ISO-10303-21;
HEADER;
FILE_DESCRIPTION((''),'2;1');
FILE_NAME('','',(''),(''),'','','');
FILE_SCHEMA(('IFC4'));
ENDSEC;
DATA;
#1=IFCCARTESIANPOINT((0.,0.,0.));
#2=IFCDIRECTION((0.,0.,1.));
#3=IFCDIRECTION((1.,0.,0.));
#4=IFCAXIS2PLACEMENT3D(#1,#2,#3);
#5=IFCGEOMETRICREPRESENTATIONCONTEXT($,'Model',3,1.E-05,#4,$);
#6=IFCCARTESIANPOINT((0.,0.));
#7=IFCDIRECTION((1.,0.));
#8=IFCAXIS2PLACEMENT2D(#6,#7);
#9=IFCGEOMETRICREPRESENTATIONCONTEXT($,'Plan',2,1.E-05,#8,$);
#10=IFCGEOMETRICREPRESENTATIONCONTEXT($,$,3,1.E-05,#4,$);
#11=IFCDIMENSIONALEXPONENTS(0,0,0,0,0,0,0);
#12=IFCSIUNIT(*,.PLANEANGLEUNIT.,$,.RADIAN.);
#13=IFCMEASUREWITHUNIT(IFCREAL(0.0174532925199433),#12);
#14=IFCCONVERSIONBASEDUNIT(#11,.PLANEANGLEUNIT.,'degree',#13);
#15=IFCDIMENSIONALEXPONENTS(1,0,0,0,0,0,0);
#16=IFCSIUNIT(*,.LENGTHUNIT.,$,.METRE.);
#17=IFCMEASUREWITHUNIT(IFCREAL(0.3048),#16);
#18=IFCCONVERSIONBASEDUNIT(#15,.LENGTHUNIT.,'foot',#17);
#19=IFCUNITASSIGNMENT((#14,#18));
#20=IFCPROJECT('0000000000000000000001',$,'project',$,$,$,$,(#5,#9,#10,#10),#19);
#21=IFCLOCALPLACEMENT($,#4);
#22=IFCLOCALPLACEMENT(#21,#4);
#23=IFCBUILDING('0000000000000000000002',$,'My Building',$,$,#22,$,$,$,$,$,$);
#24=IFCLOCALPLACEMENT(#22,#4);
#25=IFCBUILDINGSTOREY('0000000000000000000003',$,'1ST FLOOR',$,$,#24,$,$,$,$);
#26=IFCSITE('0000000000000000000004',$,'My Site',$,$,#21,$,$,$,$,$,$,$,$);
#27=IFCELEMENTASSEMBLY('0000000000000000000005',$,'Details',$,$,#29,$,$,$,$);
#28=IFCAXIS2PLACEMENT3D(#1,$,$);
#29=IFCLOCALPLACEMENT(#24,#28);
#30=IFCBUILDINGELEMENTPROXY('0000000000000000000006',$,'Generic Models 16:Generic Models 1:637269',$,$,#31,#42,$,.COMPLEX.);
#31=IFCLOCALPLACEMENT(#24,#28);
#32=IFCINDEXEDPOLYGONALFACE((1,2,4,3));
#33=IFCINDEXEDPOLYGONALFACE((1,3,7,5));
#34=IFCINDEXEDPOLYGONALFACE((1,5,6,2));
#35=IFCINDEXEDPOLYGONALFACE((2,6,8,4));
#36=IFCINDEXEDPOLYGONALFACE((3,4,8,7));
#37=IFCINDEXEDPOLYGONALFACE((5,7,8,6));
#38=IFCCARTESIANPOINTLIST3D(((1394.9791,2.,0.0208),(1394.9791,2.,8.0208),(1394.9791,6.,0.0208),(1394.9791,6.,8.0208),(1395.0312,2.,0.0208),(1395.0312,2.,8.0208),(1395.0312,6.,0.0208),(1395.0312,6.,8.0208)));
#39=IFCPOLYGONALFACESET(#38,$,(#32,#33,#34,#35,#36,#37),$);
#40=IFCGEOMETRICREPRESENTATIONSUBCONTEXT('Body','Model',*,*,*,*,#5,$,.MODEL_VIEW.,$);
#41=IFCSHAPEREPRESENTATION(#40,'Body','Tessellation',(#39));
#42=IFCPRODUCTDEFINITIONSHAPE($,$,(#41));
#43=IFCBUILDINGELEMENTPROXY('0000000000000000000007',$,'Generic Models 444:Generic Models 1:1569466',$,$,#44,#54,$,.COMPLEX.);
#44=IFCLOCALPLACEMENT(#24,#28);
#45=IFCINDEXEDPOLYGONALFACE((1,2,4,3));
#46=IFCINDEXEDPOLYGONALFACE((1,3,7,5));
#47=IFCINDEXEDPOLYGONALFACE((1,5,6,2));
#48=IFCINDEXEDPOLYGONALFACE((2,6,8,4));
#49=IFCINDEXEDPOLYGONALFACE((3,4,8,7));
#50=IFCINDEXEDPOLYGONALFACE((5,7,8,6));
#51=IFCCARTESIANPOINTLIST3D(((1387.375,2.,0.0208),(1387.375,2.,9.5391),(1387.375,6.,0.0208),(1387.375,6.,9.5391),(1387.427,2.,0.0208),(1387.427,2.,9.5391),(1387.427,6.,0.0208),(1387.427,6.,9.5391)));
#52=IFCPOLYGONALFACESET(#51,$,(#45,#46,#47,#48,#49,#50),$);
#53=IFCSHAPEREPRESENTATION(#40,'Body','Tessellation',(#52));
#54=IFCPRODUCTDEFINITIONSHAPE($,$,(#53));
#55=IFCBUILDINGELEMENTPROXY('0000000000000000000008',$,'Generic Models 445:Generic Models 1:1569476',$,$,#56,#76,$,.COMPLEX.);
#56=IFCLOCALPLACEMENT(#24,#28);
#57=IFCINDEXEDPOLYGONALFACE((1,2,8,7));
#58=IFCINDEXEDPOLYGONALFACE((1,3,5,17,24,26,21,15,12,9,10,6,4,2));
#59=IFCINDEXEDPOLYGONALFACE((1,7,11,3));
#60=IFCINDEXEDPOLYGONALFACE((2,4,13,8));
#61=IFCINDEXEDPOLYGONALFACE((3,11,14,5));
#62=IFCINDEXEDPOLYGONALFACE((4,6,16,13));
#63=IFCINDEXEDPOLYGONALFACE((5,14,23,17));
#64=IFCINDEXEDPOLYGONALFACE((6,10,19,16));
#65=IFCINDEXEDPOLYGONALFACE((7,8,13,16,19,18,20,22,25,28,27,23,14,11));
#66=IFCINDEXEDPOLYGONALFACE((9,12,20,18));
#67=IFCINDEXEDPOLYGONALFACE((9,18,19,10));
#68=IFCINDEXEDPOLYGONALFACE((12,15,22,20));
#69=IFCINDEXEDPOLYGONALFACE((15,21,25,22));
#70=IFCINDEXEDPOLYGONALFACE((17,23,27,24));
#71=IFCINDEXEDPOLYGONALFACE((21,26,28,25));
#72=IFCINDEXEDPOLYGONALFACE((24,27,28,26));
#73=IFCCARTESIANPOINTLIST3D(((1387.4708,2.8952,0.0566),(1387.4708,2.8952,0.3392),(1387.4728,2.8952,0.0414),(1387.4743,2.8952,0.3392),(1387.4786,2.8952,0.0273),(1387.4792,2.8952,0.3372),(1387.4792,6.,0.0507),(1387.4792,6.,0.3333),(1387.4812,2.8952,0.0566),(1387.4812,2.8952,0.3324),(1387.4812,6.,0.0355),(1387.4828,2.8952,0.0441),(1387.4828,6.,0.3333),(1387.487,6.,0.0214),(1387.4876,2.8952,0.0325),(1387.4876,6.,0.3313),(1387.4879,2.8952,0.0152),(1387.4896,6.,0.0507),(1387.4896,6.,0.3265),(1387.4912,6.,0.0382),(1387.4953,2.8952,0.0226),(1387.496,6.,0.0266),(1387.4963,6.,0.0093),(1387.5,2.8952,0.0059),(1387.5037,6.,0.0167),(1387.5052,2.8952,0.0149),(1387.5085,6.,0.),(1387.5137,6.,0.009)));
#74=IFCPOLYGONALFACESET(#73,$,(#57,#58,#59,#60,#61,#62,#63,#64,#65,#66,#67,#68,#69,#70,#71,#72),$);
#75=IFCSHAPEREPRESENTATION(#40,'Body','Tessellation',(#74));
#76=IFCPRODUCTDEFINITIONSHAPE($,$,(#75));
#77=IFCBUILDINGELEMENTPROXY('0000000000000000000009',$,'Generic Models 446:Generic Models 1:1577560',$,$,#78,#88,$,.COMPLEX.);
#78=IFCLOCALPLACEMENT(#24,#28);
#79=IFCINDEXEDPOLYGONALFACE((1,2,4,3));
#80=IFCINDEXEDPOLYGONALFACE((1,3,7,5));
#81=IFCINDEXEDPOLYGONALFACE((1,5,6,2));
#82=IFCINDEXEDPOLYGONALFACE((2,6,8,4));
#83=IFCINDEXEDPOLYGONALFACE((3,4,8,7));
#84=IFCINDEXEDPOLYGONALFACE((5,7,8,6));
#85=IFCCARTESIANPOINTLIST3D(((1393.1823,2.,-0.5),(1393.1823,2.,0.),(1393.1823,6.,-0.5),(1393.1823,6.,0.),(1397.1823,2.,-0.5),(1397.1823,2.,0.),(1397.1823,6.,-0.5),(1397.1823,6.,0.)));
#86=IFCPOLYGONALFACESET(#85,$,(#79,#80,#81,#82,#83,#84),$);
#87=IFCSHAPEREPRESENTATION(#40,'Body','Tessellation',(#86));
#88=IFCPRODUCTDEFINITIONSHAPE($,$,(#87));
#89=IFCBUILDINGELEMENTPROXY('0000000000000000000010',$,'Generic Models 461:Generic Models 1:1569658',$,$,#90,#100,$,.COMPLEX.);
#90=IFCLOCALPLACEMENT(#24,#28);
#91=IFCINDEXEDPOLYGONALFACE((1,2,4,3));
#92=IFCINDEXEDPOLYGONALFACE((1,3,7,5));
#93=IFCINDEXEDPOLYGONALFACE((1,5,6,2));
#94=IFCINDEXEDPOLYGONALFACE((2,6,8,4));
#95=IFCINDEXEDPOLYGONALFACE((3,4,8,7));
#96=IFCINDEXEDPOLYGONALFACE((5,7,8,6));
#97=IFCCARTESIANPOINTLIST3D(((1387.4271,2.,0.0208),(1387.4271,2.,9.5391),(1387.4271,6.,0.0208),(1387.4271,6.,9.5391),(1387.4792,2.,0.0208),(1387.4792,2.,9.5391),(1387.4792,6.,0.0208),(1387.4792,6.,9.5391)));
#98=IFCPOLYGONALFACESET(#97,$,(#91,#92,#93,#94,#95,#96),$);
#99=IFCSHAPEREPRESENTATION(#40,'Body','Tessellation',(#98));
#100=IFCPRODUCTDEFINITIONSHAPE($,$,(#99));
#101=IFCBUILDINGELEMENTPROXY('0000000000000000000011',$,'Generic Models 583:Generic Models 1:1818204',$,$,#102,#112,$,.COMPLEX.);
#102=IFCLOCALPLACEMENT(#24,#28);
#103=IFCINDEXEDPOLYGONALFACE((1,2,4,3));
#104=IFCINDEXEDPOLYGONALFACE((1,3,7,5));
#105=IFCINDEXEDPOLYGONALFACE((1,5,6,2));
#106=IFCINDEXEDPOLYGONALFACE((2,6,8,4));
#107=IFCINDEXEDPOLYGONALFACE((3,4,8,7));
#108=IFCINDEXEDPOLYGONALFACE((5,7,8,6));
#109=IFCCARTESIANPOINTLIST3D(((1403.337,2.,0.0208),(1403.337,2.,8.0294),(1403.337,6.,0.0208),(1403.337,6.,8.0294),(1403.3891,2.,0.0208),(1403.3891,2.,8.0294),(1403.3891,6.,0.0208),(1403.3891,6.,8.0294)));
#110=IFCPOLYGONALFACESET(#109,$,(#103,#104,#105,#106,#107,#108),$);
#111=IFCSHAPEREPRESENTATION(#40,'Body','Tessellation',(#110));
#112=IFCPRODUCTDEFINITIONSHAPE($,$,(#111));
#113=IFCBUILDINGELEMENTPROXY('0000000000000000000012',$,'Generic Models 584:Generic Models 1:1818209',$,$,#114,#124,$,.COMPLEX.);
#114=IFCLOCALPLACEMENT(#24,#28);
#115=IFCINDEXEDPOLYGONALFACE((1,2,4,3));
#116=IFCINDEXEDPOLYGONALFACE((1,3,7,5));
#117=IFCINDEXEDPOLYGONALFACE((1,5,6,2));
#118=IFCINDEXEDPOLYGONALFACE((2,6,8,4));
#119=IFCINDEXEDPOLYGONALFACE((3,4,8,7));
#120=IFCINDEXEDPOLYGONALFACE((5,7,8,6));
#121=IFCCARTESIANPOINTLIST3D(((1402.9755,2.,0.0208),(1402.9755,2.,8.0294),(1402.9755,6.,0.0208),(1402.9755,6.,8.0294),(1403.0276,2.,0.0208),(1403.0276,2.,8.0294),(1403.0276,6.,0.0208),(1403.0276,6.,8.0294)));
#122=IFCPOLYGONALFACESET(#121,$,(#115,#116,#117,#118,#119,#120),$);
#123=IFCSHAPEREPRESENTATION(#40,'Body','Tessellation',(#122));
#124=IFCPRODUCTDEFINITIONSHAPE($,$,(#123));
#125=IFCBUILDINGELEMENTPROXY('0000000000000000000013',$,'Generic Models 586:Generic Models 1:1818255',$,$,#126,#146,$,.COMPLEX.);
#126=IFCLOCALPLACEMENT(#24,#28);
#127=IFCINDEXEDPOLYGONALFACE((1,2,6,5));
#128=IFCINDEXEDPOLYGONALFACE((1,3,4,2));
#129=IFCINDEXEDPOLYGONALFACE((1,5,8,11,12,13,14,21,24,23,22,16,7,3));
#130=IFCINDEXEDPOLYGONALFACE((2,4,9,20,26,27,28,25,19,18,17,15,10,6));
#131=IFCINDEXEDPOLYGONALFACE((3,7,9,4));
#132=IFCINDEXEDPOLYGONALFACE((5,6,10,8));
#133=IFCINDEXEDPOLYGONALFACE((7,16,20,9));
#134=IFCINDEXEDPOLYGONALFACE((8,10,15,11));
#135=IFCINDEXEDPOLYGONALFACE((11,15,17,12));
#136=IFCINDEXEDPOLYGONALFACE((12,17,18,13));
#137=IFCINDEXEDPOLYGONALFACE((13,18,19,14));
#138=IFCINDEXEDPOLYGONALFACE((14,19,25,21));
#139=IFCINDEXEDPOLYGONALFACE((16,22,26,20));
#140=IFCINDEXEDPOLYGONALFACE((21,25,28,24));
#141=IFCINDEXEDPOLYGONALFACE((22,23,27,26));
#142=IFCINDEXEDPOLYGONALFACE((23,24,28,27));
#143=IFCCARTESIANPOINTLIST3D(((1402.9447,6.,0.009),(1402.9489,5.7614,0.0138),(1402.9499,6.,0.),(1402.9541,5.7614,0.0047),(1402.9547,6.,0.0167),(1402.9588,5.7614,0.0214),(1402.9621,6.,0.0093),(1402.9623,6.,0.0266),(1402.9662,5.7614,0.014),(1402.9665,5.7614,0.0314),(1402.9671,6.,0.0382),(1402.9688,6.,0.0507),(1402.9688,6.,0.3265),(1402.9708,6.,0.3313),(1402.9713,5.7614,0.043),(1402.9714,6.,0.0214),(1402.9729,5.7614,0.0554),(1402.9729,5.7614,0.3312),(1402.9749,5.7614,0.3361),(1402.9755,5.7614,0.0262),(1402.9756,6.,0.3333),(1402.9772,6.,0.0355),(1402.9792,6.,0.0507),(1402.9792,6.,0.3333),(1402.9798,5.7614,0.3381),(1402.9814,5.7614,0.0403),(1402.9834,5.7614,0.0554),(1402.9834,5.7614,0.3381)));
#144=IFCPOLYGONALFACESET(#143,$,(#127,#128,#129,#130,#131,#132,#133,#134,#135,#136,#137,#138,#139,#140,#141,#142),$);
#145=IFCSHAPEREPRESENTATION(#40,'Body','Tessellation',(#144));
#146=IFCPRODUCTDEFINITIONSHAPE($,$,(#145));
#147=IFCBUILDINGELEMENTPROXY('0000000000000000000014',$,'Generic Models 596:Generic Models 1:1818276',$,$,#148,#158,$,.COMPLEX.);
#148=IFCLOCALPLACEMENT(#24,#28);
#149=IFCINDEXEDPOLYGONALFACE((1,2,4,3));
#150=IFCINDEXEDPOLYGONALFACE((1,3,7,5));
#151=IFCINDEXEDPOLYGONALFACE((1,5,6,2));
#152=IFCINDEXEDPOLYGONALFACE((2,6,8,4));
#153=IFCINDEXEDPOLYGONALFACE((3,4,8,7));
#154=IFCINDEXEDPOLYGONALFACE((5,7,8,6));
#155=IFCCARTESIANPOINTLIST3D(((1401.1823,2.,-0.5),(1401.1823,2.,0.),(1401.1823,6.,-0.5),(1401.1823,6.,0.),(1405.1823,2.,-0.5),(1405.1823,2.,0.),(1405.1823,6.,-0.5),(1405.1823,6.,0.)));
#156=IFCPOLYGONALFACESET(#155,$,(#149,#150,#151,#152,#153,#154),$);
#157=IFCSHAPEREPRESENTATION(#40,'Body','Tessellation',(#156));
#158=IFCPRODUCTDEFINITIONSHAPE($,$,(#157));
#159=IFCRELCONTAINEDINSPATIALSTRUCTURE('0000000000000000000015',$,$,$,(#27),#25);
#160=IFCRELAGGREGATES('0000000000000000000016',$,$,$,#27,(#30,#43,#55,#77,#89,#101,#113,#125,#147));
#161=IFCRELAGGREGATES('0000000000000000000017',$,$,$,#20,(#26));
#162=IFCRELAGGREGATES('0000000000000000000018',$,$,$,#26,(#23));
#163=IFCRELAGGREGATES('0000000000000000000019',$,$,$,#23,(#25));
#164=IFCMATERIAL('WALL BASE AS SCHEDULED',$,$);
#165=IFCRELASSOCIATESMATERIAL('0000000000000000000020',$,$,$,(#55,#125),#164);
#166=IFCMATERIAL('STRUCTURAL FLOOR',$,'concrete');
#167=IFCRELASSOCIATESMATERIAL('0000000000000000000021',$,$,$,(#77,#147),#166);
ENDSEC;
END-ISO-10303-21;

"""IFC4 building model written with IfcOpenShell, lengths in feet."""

from ifc_helpers import new_model, entity, si_unit, converted_unit, frame, origin_with_axes, origin_2d_with_axis, place, context, subcontext, project, spatial, polyline, line, indexed_curve, outline, extrude, material, element, aggregate, save


model = new_model("IFC4")

# Units and contexts
model_context = context("Model", 3, precision=1e-05, world=origin_with_axes())
plan_context = context("Plan", 2, precision=1e-05, world=origin_2d_with_axis())
context_of_model = context(None, 3, precision=1e-05, world=origin_with_axes())
body_context = subcontext(model_context, "Body", "Model", "MODEL_VIEW")
ifc_project = project(units=[converted_unit("PLANEANGLEUNIT", "degree", entity("IfcReal", 0.0174532925199433), si_unit("PLANEANGLEUNIT", "RADIAN"), dimensions=[0, 0, 0, 0, 0, 0, 0]), converted_unit("LENGTHUNIT", "foot", entity("IfcReal", 0.3048), si_unit("LENGTHUNIT", "METRE"), dimensions=[1, 0, 0, 0, 0, 0, 0])], contexts=[model_context, plan_context, context_of_model, context_of_model])

# Site, building, storey
site_placement = place(None, origin_with_axes())
site = spatial("IfcSite", under=ifc_project, at=site_placement, Name="My Site")
building_placement = place(site_placement, origin_with_axes())
building = spatial("IfcBuilding", under=site, at=building_placement, Name="My Building")
storey_placement = place(building_placement, origin_with_axes())
storey = spatial("IfcBuildingStorey", under=building, at=storey_placement, Name="1ST FLOOR")

# Element assembly, building element proxies
assembly_placement = place(storey_placement, origin_with_axes())
assembly = element("IfcElementAssembly", 1, at=assembly_placement, inside=storey, Name="Details")
ifc_material_1 = material(Name="WALL BASE AS SCHEDULED")
ifc_material_2 = material(Name="STRUCTURAL FLOOR", Category="concrete")
proxy_1_placement = place(assembly_placement, frame((1394.9791, 6.0, 0.0208), z_axis=(0.0, -1.0, 0.0), x_axis=(0.0, 0.0, 1.0)))
proxy_1 = element("IfcBuildingElementProxy", 2, at=proxy_1_placement, Name="Generic Models 16:Generic Models 1:637269", PredefinedType="COMPLEX", context=body_context, shape_type="SweptSolid", body=[
    extrude(outline(polyline([(-0.026, -4.0), (0.026, -4.0), (0.026, 4.0), (-0.026, 4.0), (-0.026, -4.0)])), frame((4.0, -0.026, 0.0), z_axis=(0.0, 0.0, -1.0), x_axis=(0.0, 1.0, 0.0)), (0.0, 0.0, -1.0), 4.0),
])
proxy_2_placement = place(assembly_placement, frame((1387.375, 6.0, 0.0208), z_axis=(0.0, -1.0, 0.0), x_axis=(0.0, 0.0, 1.0)))
proxy_2 = element("IfcBuildingElementProxy", 3, at=proxy_2_placement, Name="Generic Models 444:Generic Models 1:1569466", PredefinedType="COMPLEX", context=body_context, shape_type="SweptSolid", body=[
    extrude(outline(polyline([(-4.7591, -0.026), (4.7591, -0.026), (4.7591, 0.026), (-4.7591, 0.026), (-4.7591, -0.026)])), frame((4.7591, -0.026, 0.0), z_axis=(0.0, 0.0, -1.0), x_axis=(1.0, 0.0, 0.0)), (0.0, 0.0, -1.0), 4.0),
])
proxy_3_placement = place(assembly_placement, frame((1387.4792, 6.0, 0.0), z_axis=(0.0, -1.0, 0.0), x_axis=(0.0, 0.0, 1.0)))
proxy_3 = element("IfcBuildingElementProxy", 4, at=proxy_3_placement, material=ifc_material_1, Name="Generic Models 445:Generic Models 1:1569476", PredefinedType="COMPLEX", context=body_context, shape_type="SweptSolid", body=[
    extrude(outline(polyline([(0.2206, 0.0), (0.2204, 0.0036), (0.2182, 0.0083), (0.2132, 0.01), (-0.0621, -0.0058), (-0.0747, -0.0049), (-0.0865, -0.0007), (-0.0969, 0.0063), (-0.1051, 0.0158), (-0.1138, 0.0101), (-0.1038, -0.0014), (-0.0912, -0.01), (-0.0768, -0.0151), (-0.0615, -0.0162), (0.2206, 0.0)])), frame((0.113, -0.0126, 0.0), z_axis=(0.0, 0.0, -1.0), x_axis=(0.998358, 0.057286, 0.0)), (0.002054, -0.002598, -0.999995), 3.1048),
])
proxy_4_placement = place(assembly_placement, frame((1393.1823, 6.0, -0.5), z_axis=(0.0, -1.0, 0.0), x_axis=(0.0, 0.0, 1.0)))
proxy_4 = element("IfcBuildingElementProxy", 5, at=proxy_4_placement, material=ifc_material_2, Name="Generic Models 446:Generic Models 1:1577560", PredefinedType="COMPLEX", context=body_context, shape_type="SweptSolid", body=[
    extrude(outline(polyline([(-2.0, -0.25), (2.0, -0.25), (2.0, 0.25), (-2.0, 0.25), (-2.0, -0.25)])), frame((0.25, -2.0, 0.0), z_axis=(0.0, 0.0, -1.0), x_axis=(0.0, 1.0, 0.0)), (0.0, 0.0, -1.0), 4.0),
])
proxy_5_placement = place(assembly_placement, frame((1387.4271, 6.0, 0.0208), z_axis=(0.0, -1.0, 0.0), x_axis=(0.0, 0.0, 1.0)))
proxy_5 = element("IfcBuildingElementProxy", 6, at=proxy_5_placement, Name="Generic Models 461:Generic Models 1:1569658", PredefinedType="COMPLEX", context=body_context, shape_type="SweptSolid", body=[
    extrude(outline(polyline([(-4.7591, -0.026), (4.7591, -0.026), (4.7591, 0.026), (-4.7591, 0.026), (-4.7591, -0.026)])), frame((4.7591, -0.026, 0.0), z_axis=(0.0, 0.0, -1.0), x_axis=(-1.0, 0.0, 0.0)), (0.0, 0.0, -1.0), 4.0),
])
proxy_6_placement = place(assembly_placement, frame((1403.337, 6.0, 0.0208), z_axis=(0.0, -1.0, 0.0), x_axis=(0.0, 0.0, 1.0)))
proxy_6 = element("IfcBuildingElementProxy", 7, at=proxy_6_placement, Name="Generic Models 583:Generic Models 1:1818204", PredefinedType="COMPLEX", context=body_context, shape_type="SweptSolid", body=[
    extrude(outline(indexed_curve([(4.0043, 0.026), (4.0043, -0.026), (-4.0043, -0.026), (-4.0043, 0.026)], segments=[line(4, 1), line(1, 2), line(2, 3), line(3, 4)], self_intersect=False)), frame((4.0043, -0.026, 0.0), z_axis=(0.0, 0.0, -1.0), x_axis=(-1.0, 0.0, 0.0)), (0.0, 0.0, -1.0), 4.0),
])
proxy_7_placement = place(assembly_placement, frame((1402.9755, 6.0, 0.0208), z_axis=(0.0, -1.0, 0.0), x_axis=(0.0, 0.0, 1.0)))
proxy_7 = element("IfcBuildingElementProxy", 8, at=proxy_7_placement, Name="Generic Models 584:Generic Models 1:1818209", PredefinedType="COMPLEX", context=body_context, shape_type="SweptSolid", body=[
    extrude(outline(polyline([(-0.026, -4.0043), (0.026, -4.0043), (0.026, 4.0043), (-0.026, 4.0043), (-0.026, -4.0043)])), frame((4.0043, -0.026, 0.0), z_axis=(0.0, 0.0, -1.0), x_axis=(0.0, 1.0, 0.0)), (0.0, 0.0, -1.0), 4.0),
])
proxy_8_placement = place(assembly_placement, frame((1402.9447, 6.0, 0.0), z_axis=(0.0, -1.0, 0.0), x_axis=(0.0, 0.0, 1.0)))
proxy_8 = element("IfcBuildingElementProxy", 9, at=proxy_8_placement, material=ifc_material_1, Name="Generic Models 586:Generic Models 1:1818255", PredefinedType="COMPLEX", context=body_context, shape_type="SweptSolid", body=[
    extrude(outline(polyline([(0.0748, 0.0), (0.0624, -0.0017), (-0.2134, -0.0039), (-0.2182, -0.0059), (-0.2202, -0.0108), (-0.2202, -0.0144), (0.0625, -0.0122), (0.0776, -0.01), (0.0917, -0.0041), (0.1037, 0.0053), (0.1129, 0.0175), (0.1039, 0.0226), (0.0963, 0.0126), (0.0864, 0.0049), (0.0748, 0.0)])), frame((0.113, -0.0218, 0.0), z_axis=(0.0, 0.0, -1.0), x_axis=(-0.99997, -0.007803, 0.0)), (-0.019684, -0.017536, -0.999652), 0.2387),
])
proxy_9_placement = place(assembly_placement, frame((1401.1823, 6.0, -0.5), z_axis=(0.0, -1.0, 0.0), x_axis=(0.0, 0.0, 1.0)))
proxy_9 = element("IfcBuildingElementProxy", 10, at=proxy_9_placement, material=ifc_material_2, Name="Generic Models 596:Generic Models 1:1818276", PredefinedType="COMPLEX", context=body_context, shape_type="SweptSolid", body=[
    extrude(outline(polyline([(-0.25, -2.0), (0.25, -2.0), (0.25, 2.0), (-0.25, 2.0), (-0.25, -2.0)])), frame((0.25, -2.0, 0.0), z_axis=(0.0, 0.0, -1.0), x_axis=(-1.0, 0.0, 0.0)), (0.0, 0.0, -1.0), 4.0),
])
aggregate(assembly, [proxy_1, proxy_2, proxy_3, proxy_4, proxy_5, proxy_6, proxy_7, proxy_8, proxy_9])

save(model, "model.ifc")
